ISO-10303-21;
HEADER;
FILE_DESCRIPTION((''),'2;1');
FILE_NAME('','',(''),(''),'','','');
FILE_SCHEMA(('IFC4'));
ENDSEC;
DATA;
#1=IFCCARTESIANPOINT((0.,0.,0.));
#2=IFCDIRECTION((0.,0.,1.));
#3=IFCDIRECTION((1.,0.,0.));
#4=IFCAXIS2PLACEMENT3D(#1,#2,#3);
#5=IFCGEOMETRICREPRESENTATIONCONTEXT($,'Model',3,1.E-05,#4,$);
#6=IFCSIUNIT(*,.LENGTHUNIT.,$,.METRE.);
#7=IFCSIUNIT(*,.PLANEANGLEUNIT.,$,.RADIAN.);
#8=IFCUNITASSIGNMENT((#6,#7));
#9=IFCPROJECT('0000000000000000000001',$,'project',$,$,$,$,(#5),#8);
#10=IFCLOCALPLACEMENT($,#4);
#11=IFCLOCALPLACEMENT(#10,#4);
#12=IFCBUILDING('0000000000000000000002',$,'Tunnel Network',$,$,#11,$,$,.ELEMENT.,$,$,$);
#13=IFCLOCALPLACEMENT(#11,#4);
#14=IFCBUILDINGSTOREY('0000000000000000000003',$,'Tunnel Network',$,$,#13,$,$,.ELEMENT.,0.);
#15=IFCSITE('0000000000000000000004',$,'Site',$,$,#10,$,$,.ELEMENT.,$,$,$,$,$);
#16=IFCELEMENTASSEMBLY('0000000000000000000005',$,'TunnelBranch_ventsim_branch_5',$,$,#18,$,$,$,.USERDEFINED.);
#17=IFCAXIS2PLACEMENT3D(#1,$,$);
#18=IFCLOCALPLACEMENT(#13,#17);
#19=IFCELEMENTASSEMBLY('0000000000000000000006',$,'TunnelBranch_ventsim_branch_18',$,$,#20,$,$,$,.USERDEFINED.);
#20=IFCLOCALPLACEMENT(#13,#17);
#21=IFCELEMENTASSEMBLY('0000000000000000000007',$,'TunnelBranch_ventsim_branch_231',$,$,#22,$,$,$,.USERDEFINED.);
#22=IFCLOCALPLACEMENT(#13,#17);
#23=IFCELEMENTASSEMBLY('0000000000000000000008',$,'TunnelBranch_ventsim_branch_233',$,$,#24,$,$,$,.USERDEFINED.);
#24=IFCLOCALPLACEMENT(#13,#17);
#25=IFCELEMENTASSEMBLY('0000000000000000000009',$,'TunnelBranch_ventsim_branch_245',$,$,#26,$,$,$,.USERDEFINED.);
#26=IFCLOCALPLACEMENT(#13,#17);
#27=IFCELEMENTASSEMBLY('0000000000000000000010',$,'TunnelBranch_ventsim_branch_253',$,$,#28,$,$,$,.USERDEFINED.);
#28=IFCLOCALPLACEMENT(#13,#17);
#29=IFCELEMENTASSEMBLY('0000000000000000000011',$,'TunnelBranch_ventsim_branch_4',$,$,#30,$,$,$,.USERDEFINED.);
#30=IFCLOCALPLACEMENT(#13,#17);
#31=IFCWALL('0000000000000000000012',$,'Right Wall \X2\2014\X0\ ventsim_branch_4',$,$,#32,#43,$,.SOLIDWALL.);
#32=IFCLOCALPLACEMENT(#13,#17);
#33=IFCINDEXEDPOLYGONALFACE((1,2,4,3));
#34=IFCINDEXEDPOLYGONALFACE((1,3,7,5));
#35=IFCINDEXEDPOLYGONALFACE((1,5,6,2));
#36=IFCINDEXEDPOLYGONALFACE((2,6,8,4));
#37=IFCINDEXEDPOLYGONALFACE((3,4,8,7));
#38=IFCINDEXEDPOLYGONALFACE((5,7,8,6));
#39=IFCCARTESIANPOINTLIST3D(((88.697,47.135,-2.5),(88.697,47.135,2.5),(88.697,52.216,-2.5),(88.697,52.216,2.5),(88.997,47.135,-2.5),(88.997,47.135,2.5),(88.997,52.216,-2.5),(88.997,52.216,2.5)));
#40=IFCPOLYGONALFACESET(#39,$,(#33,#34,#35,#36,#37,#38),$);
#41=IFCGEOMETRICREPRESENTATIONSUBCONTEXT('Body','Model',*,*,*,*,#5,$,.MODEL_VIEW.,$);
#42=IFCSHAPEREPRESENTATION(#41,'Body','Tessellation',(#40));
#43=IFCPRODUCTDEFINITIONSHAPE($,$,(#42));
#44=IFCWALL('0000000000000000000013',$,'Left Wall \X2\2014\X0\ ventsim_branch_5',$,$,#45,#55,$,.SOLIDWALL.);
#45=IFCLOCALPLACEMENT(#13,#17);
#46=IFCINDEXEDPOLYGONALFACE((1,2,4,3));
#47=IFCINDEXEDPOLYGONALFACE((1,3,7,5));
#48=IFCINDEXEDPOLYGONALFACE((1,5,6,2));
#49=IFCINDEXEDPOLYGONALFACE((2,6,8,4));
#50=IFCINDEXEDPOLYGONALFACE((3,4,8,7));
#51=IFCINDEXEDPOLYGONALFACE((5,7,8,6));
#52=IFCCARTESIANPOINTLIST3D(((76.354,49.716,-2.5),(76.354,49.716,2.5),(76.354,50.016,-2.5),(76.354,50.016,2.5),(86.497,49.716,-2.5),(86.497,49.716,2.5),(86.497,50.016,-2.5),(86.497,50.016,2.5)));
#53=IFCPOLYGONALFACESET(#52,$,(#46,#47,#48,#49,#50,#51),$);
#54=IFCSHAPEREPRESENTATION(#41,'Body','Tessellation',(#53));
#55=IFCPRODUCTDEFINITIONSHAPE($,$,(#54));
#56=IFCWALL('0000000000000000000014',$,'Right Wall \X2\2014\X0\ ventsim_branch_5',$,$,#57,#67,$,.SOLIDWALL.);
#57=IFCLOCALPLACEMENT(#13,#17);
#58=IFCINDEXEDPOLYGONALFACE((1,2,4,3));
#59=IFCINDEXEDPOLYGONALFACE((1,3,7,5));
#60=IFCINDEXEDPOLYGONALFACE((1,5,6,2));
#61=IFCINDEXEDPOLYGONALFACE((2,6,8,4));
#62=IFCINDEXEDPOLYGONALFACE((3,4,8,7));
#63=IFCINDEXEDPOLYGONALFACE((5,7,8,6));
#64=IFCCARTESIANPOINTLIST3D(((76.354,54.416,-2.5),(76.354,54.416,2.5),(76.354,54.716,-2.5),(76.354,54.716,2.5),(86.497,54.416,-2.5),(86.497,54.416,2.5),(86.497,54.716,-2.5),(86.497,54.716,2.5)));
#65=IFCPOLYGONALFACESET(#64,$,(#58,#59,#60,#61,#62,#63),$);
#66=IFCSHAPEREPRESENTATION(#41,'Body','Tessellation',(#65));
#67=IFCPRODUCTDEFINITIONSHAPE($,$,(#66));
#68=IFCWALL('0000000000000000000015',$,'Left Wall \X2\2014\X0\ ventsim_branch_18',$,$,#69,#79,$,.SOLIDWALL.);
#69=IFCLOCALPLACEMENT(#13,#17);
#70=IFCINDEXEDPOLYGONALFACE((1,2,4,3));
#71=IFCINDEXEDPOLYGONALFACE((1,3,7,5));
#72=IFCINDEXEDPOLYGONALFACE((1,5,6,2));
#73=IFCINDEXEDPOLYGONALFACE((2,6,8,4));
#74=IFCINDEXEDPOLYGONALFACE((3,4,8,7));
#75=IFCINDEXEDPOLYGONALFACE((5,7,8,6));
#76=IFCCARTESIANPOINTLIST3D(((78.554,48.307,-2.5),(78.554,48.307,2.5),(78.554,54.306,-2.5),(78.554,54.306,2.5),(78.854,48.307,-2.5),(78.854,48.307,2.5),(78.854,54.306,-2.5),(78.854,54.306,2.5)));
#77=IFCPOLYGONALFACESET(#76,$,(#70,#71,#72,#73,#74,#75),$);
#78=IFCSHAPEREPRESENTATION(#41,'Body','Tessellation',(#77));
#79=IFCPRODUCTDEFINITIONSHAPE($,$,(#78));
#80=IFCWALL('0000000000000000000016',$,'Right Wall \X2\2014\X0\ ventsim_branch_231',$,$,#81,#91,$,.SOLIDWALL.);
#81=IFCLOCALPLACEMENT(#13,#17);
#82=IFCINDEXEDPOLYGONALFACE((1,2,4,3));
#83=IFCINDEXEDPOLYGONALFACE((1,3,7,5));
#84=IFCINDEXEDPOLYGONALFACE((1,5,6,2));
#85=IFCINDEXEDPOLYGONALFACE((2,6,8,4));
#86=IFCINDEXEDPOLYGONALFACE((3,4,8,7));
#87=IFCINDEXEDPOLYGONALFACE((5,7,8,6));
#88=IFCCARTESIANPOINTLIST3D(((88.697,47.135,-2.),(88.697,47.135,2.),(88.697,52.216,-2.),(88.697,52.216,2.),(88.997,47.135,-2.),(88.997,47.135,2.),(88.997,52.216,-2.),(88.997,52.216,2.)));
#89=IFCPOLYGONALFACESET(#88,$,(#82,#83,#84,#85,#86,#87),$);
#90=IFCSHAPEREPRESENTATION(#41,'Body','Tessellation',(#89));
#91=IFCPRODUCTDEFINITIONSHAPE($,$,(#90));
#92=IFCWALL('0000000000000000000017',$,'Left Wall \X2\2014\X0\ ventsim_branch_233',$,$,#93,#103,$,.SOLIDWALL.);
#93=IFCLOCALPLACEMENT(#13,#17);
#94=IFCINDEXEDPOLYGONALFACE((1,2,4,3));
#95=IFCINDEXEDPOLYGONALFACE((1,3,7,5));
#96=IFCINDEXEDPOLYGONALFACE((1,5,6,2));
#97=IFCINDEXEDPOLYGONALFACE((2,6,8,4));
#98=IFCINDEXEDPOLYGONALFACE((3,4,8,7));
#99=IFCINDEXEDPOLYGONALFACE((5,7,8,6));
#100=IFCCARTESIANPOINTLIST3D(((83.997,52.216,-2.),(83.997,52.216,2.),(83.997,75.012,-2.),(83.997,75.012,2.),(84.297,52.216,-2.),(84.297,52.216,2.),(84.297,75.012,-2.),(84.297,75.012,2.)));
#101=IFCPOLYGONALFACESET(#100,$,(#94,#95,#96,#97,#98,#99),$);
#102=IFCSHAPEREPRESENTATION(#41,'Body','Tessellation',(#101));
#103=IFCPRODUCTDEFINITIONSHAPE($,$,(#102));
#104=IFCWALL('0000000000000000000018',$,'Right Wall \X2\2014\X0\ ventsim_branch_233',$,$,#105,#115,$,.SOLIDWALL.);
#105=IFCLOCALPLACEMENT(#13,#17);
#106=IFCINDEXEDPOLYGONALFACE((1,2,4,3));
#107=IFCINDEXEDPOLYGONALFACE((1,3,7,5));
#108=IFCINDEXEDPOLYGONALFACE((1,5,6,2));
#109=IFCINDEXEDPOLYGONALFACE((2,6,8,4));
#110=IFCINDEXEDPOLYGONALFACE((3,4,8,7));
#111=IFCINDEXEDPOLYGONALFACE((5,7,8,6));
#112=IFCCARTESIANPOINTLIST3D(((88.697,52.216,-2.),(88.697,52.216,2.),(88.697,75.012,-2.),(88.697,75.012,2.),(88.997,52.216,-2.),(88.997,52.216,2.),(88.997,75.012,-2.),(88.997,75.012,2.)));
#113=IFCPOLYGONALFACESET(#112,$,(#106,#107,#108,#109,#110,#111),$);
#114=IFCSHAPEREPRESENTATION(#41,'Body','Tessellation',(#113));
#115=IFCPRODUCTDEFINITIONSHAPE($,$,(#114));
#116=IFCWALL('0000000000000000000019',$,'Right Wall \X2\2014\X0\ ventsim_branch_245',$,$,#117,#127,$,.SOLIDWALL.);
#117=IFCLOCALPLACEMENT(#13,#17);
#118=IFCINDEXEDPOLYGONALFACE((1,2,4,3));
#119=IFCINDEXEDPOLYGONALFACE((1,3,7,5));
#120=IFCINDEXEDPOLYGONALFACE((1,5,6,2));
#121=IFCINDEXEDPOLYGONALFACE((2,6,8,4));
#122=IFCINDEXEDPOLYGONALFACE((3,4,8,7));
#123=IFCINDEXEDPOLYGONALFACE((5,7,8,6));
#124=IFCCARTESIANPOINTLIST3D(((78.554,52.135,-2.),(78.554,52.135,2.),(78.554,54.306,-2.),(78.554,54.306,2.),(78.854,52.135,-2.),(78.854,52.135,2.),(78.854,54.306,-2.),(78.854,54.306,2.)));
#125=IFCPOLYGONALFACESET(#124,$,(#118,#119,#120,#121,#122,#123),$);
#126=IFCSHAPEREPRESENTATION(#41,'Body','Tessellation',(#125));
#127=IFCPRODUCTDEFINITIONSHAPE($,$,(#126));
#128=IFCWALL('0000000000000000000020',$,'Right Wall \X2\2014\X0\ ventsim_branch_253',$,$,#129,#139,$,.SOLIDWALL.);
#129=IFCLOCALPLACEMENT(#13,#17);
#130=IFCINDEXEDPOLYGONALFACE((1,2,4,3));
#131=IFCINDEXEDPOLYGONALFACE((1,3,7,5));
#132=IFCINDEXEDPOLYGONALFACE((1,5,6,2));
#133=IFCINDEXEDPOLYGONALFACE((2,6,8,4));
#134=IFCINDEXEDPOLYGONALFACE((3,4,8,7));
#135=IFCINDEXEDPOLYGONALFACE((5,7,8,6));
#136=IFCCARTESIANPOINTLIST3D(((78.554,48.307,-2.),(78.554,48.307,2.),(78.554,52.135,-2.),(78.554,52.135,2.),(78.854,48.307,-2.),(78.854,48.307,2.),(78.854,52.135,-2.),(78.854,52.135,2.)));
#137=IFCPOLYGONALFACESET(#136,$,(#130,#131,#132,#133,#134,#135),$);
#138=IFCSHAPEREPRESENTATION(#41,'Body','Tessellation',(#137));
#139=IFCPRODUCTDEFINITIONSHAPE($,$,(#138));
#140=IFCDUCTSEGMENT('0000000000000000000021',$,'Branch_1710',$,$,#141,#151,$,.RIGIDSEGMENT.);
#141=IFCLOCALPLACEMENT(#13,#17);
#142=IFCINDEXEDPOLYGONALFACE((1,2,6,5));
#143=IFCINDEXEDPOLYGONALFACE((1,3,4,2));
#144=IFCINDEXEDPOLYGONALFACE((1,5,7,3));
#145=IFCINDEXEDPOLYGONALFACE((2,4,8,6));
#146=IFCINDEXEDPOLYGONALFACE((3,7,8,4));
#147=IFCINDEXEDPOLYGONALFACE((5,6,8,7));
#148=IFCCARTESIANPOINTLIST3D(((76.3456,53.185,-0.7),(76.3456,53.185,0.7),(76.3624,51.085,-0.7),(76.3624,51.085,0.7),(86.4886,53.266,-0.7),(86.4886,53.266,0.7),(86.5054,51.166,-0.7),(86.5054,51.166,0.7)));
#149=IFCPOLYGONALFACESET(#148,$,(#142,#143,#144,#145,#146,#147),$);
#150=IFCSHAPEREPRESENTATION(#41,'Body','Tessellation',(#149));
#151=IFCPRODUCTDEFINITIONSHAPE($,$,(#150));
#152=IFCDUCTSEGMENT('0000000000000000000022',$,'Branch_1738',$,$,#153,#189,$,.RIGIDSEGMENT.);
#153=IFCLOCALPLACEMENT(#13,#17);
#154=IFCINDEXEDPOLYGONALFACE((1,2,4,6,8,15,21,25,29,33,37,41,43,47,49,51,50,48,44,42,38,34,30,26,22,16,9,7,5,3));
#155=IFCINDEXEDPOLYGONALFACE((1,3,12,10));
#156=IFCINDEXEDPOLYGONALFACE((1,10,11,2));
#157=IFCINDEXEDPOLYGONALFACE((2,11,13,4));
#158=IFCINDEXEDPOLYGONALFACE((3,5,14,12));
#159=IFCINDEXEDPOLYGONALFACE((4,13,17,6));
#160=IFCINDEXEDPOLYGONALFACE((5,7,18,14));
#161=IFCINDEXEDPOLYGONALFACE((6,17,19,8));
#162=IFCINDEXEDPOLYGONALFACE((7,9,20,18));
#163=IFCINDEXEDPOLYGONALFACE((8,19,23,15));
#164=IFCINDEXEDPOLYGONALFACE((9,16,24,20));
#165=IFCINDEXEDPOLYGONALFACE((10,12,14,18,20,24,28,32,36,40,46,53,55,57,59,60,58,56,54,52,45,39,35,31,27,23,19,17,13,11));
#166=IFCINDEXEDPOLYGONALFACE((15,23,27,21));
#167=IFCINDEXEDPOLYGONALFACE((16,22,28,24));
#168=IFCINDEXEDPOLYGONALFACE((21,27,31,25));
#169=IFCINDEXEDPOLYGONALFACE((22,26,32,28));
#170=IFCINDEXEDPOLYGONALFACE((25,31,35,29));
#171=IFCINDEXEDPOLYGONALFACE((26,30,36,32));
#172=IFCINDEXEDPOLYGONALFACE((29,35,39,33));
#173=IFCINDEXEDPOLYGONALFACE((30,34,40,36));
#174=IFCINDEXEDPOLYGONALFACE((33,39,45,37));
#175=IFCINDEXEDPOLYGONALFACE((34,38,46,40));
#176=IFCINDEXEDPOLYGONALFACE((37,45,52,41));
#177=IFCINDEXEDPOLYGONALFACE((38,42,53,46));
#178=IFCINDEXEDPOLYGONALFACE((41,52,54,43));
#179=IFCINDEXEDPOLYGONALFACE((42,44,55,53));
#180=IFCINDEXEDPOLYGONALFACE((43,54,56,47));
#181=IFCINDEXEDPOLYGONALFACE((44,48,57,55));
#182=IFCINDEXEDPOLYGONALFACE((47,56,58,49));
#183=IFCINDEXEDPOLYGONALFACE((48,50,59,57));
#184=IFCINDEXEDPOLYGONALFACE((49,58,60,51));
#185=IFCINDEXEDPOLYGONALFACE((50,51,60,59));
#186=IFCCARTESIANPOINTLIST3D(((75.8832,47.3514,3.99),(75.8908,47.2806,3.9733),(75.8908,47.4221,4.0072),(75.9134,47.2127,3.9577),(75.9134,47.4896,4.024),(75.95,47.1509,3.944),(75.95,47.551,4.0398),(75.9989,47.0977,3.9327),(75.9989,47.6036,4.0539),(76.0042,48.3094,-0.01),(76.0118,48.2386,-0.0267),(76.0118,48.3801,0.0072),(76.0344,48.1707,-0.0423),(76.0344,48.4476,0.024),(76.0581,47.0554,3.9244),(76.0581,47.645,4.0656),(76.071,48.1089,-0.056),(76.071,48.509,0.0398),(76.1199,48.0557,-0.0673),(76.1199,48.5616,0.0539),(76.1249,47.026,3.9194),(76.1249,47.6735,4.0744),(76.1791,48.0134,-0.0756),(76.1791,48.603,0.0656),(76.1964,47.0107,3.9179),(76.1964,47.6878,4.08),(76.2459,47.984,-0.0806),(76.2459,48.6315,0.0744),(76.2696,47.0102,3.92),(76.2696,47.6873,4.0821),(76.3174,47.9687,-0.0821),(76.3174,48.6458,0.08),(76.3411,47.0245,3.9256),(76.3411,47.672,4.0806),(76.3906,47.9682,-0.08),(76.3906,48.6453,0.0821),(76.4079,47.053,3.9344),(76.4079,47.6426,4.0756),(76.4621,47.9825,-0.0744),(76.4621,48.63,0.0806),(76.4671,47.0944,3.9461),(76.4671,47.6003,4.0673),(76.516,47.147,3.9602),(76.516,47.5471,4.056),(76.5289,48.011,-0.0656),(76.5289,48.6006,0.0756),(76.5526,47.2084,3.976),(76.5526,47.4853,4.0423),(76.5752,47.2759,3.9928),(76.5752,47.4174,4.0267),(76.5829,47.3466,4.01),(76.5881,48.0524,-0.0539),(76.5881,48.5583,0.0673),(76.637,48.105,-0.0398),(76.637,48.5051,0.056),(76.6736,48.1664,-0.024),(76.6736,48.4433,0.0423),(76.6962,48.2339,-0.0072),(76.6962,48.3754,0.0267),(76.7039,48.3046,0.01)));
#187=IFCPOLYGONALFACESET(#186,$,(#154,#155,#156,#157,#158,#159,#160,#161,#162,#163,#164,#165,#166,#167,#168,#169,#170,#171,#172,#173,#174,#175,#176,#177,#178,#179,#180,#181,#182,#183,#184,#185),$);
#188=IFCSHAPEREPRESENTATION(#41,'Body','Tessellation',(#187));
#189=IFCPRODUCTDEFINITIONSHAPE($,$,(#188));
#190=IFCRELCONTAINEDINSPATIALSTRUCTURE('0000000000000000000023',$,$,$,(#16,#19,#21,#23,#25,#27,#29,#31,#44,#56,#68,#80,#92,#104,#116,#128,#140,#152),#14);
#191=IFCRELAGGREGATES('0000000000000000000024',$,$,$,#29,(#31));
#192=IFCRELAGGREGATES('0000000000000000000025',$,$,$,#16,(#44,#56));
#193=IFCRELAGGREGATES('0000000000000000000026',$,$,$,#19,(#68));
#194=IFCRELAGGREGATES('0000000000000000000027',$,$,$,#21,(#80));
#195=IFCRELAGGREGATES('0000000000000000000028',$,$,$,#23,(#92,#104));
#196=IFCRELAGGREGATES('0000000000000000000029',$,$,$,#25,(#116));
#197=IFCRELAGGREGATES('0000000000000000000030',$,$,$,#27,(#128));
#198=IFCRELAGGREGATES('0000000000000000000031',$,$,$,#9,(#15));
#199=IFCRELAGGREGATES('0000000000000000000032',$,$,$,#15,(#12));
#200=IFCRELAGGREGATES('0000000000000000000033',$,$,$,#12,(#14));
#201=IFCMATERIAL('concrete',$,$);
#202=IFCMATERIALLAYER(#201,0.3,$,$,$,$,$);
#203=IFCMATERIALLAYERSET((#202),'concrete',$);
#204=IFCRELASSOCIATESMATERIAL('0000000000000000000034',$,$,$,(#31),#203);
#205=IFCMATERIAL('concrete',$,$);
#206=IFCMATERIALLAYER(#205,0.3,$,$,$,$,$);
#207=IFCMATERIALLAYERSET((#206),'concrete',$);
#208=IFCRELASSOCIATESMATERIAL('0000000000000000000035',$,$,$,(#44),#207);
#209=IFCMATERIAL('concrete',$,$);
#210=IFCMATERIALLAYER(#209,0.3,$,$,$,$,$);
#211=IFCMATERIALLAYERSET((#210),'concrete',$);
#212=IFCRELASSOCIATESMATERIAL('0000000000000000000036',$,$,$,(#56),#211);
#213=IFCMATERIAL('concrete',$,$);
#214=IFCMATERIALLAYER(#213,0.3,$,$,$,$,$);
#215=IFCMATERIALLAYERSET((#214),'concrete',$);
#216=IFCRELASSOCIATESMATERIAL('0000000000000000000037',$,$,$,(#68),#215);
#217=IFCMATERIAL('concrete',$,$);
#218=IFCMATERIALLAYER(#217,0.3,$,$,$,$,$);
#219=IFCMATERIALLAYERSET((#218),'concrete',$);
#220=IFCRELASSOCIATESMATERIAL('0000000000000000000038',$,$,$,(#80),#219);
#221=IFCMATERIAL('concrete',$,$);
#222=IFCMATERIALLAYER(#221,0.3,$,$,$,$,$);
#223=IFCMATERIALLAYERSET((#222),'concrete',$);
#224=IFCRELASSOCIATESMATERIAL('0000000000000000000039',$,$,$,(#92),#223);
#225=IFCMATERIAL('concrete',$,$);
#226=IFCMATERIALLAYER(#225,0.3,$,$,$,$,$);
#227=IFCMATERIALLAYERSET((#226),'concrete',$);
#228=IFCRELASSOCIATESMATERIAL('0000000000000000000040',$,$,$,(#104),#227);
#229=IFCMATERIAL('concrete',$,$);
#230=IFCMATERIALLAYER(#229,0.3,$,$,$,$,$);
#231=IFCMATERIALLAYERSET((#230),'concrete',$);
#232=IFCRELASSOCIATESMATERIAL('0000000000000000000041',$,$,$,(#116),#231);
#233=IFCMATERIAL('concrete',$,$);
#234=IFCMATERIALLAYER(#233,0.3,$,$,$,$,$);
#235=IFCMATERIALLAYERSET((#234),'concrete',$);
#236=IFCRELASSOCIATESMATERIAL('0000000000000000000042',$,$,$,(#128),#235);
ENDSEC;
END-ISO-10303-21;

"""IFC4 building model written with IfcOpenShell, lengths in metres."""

from ifc_helpers import new_model, si_unit, frame, origin_with_axes, origin_2d_with_axis, place, context, subcontext, project, spatial, rectangle, circle, extrude, material, layer, layer_set, layer_usage, element, aggregate, save


model = new_model("IFC4")

# Units and contexts
model_context = context("Model", 3, precision=1e-05, world=origin_with_axes())
body_context = subcontext(model_context, "Body", "Model", "MODEL_VIEW")
ifc_project = project(units=[si_unit("LENGTHUNIT", "METRE"), si_unit("PLANEANGLEUNIT", "RADIAN")], contexts=[model_context])

# Site, building, storey
site_placement = place(None, origin_with_axes())
site = spatial("IfcSite", under=ifc_project, at=site_placement, Name="Site", CompositionType="ELEMENT")
building_placement = place(site_placement, origin_with_axes())
building = spatial("IfcBuilding", under=site, at=building_placement, Name="Tunnel Network", CompositionType="ELEMENT")
storey_placement = place(building_placement, origin_with_axes())
storey = spatial("IfcBuildingStorey", under=building, at=storey_placement, Name="Tunnel Network", CompositionType="ELEMENT", Elevation=0.0)

# Element assemblies
assembly_1_placement = place(storey_placement, frame((86.497, 49.866, 0.0), z_axis=(-1.0, 0.0, 0.0), x_axis=(0.0, 1.0, 0.0)))
assembly_1 = element("IfcElementAssembly", 1, at=assembly_1_placement, inside=storey, Name="TunnelBranch_ventsim_branch_5", PredefinedType="USERDEFINED")
assembly_2_placement = place(storey_placement, frame((78.704, 54.306, 0.0), z_axis=(0.0, -1.0, 0.0), x_axis=(-1.0, 0.0, 0.0)))
assembly_2 = element("IfcElementAssembly", 2, at=assembly_2_placement, inside=storey, Name="TunnelBranch_ventsim_branch_18", PredefinedType="USERDEFINED")
assembly_3_placement = place(storey_placement, frame((84.147, 47.135, 0.0), z_axis=(0.0, 1.0, 0.0), x_axis=(1.0, 0.0, 0.0)))
assembly_3 = element("IfcElementAssembly", 3, at=assembly_3_placement, inside=storey, Name="TunnelBranch_ventsim_branch_231", PredefinedType="USERDEFINED")
assembly_4_placement = place(storey_placement, frame((84.147, 52.216, 0.0), z_axis=(0.0, 1.0, 0.0), x_axis=(1.0, 0.0, 0.0)))
assembly_4 = element("IfcElementAssembly", 4, at=assembly_4_placement, inside=storey, Name="TunnelBranch_ventsim_branch_233", PredefinedType="USERDEFINED")
assembly_5_placement = place(storey_placement, frame((74.004, 52.135, 0.0), z_axis=(0.0, 1.0, 0.0), x_axis=(1.0, 0.0, 0.0)))
assembly_5 = element("IfcElementAssembly", 5, at=assembly_5_placement, inside=storey, Name="TunnelBranch_ventsim_branch_245", PredefinedType="USERDEFINED")
assembly_6_placement = place(storey_placement, frame((74.004, 48.307, 0.0), z_axis=(0.0, 1.0, 0.0), x_axis=(1.0, 0.0, 0.0)))
assembly_6 = element("IfcElementAssembly", 6, at=assembly_6_placement, inside=storey, Name="TunnelBranch_ventsim_branch_253", PredefinedType="USERDEFINED")

# Element assembly, wall
assembly_7_placement = place(storey_placement, frame((84.147, 47.135, 0.0), z_axis=(0.0, 1.0, 0.0), x_axis=(1.0, 0.0, 0.0)))
assembly_7 = element("IfcElementAssembly", 7, at=assembly_7_placement, inside=storey, Name="TunnelBranch_ventsim_branch_4", PredefinedType="USERDEFINED")
ifc_material_1 = material(Name="concrete")
ifc_layer_1 = layer(ifc_material_1, 0.3)
ifc_layer_set_1 = layer_set([ifc_layer_1], Name="concrete")
ifc_layer_usage_1 = layer_usage(ifc_layer_set_1, "AXIS2", "POSITIVE", 0.0)
wall_1_placement = place(storey_placement, frame((88.847, 47.135, 0.0), z_axis=(0.0, 1.0, 0.0), x_axis=(1.0, 0.0, 0.0)))
wall_1 = element("IfcWall", 8, at=wall_1_placement, inside=storey, material=ifc_layer_usage_1, Name="Right Wall — ventsim_branch_4", PredefinedType="SOLIDWALL", context=body_context, shape_type="SweptSolid", body=[
    extrude(rectangle(XDim=0.3, YDim=5.0, at=origin_2d_with_axis()), origin_with_axes(), (0.0, 0.0, 1.0), 5.081),
])
aggregate(assembly_7, [wall_1])

# Walls
ifc_material_2 = material(Name="concrete")
ifc_layer_2 = layer(ifc_material_2, 0.3)
ifc_layer_set_2 = layer_set([ifc_layer_2], Name="concrete")
ifc_layer_usage_2 = layer_usage(ifc_layer_set_2, "AXIS2", "POSITIVE", 0.0)
wall_2_placement = place(storey_placement, frame((86.497, 49.866, 0.0), z_axis=(-1.0, 0.0, 0.0), x_axis=(0.0, 1.0, 0.0)))
wall_2 = element("IfcWall", 9, at=wall_2_placement, inside=storey, material=ifc_layer_usage_2, Name="Left Wall — ventsim_branch_5", PredefinedType="SOLIDWALL", context=body_context, shape_type="SweptSolid", body=[
    extrude(rectangle(XDim=0.3, YDim=5.0, at=origin_2d_with_axis()), origin_with_axes(), (0.0, 0.0, 1.0), 10.143),
])
ifc_material_3 = material(Name="concrete")
ifc_layer_3 = layer(ifc_material_3, 0.3)
ifc_layer_set_3 = layer_set([ifc_layer_3], Name="concrete")
ifc_layer_usage_3 = layer_usage(ifc_layer_set_3, "AXIS2", "POSITIVE", 0.0)
wall_3_placement = place(storey_placement, frame((86.497, 54.566, 0.0), z_axis=(-1.0, 0.0, 0.0), x_axis=(0.0, 1.0, 0.0)))
wall_3 = element("IfcWall", 10, at=wall_3_placement, inside=storey, material=ifc_layer_usage_3, Name="Right Wall — ventsim_branch_5", PredefinedType="SOLIDWALL", context=body_context, shape_type="SweptSolid", body=[
    extrude(rectangle(XDim=0.3, YDim=5.0, at=origin_2d_with_axis()), origin_with_axes(), (0.0, 0.0, 1.0), 10.143),
])
aggregate(assembly_1, [wall_2, wall_3])
ifc_material_4 = material(Name="concrete")
ifc_layer_4 = layer(ifc_material_4, 0.3)
ifc_layer_set_4 = layer_set([ifc_layer_4], Name="concrete")
ifc_layer_usage_4 = layer_usage(ifc_layer_set_4, "AXIS2", "POSITIVE", 0.0)
wall_4_placement = place(storey_placement, frame((78.704, 54.306, 0.0), z_axis=(0.0, -1.0, 0.0), x_axis=(-1.0, 0.0, 0.0)))
wall_4 = element("IfcWall", 11, at=wall_4_placement, inside=storey, material=ifc_layer_usage_4, Name="Left Wall — ventsim_branch_18", PredefinedType="SOLIDWALL", context=body_context, shape_type="SweptSolid", body=[
    extrude(rectangle(XDim=0.3, YDim=5.0, at=origin_2d_with_axis()), origin_with_axes(), (0.0, 0.0, 1.0), 5.999),
])
aggregate(assembly_2, [wall_4])
ifc_material_5 = material(Name="concrete")
ifc_layer_5 = layer(ifc_material_5, 0.3)
ifc_layer_set_5 = layer_set([ifc_layer_5], Name="concrete")
ifc_layer_usage_5 = layer_usage(ifc_layer_set_5, "AXIS2", "POSITIVE", 0.0)
wall_5_placement = place(storey_placement, frame((88.847, 47.135, 0.0), z_axis=(0.0, 1.0, 0.0), x_axis=(1.0, 0.0, 0.0)))
wall_5 = element("IfcWall", 12, at=wall_5_placement, inside=storey, material=ifc_layer_usage_5, Name="Right Wall — ventsim_branch_231", PredefinedType="SOLIDWALL", context=body_context, shape_type="SweptSolid", body=[
    extrude(rectangle(XDim=0.3, YDim=4.0, at=origin_2d_with_axis()), origin_with_axes(), (0.0, 0.0, 1.0), 5.081),
])
aggregate(assembly_3, [wall_5])
ifc_material_6 = material(Name="concrete")
ifc_layer_6 = layer(ifc_material_6, 0.3)
ifc_layer_set_6 = layer_set([ifc_layer_6], Name="concrete")
ifc_layer_usage_6 = layer_usage(ifc_layer_set_6, "AXIS2", "POSITIVE", 0.0)
wall_6_placement = place(storey_placement, frame((84.147, 52.216, 0.0), z_axis=(0.0, 1.0, 0.0), x_axis=(1.0, 0.0, 0.0)))
wall_6 = element("IfcWall", 13, at=wall_6_placement, inside=storey, material=ifc_layer_usage_6, Name="Left Wall — ventsim_branch_233", PredefinedType="SOLIDWALL", context=body_context, shape_type="SweptSolid", body=[
    extrude(rectangle(XDim=0.3, YDim=4.0, at=origin_2d_with_axis()), origin_with_axes(), (0.0, 0.0, 1.0), 22.796),
])
ifc_material_7 = material(Name="concrete")
ifc_layer_7 = layer(ifc_material_7, 0.3)
ifc_layer_set_7 = layer_set([ifc_layer_7], Name="concrete")
ifc_layer_usage_7 = layer_usage(ifc_layer_set_7, "AXIS2", "POSITIVE", 0.0)
wall_7_placement = place(storey_placement, frame((88.847, 52.216, 0.0), z_axis=(0.0, 1.0, 0.0), x_axis=(1.0, 0.0, 0.0)))
wall_7 = element("IfcWall", 14, at=wall_7_placement, inside=storey, material=ifc_layer_usage_7, Name="Right Wall — ventsim_branch_233", PredefinedType="SOLIDWALL", context=body_context, shape_type="SweptSolid", body=[
    extrude(rectangle(XDim=0.3, YDim=4.0, at=origin_2d_with_axis()), origin_with_axes(), (0.0, 0.0, 1.0), 22.796),
])
aggregate(assembly_4, [wall_6, wall_7])
ifc_material_8 = material(Name="concrete")
ifc_layer_8 = layer(ifc_material_8, 0.3)
ifc_layer_set_8 = layer_set([ifc_layer_8], Name="concrete")
ifc_layer_usage_8 = layer_usage(ifc_layer_set_8, "AXIS2", "POSITIVE", 0.0)
wall_8_placement = place(storey_placement, frame((78.704, 52.135, 0.0), z_axis=(0.0, 1.0, 0.0), x_axis=(1.0, 0.0, 0.0)))
wall_8 = element("IfcWall", 15, at=wall_8_placement, inside=storey, material=ifc_layer_usage_8, Name="Right Wall — ventsim_branch_245", PredefinedType="SOLIDWALL", context=body_context, shape_type="SweptSolid", body=[
    extrude(rectangle(XDim=0.3, YDim=4.0, at=origin_2d_with_axis()), origin_with_axes(), (0.0, 0.0, 1.0), 2.171),
])
aggregate(assembly_5, [wall_8])
ifc_material_9 = material(Name="concrete")
ifc_layer_9 = layer(ifc_material_9, 0.3)
ifc_layer_set_9 = layer_set([ifc_layer_9], Name="concrete")
ifc_layer_usage_9 = layer_usage(ifc_layer_set_9, "AXIS2", "POSITIVE", 0.0)
wall_9_placement = place(storey_placement, frame((78.704, 48.307, 0.0), z_axis=(0.0, 1.0, 0.0), x_axis=(1.0, 0.0, 0.0)))
wall_9 = element("IfcWall", 16, at=wall_9_placement, inside=storey, material=ifc_layer_usage_9, Name="Right Wall — ventsim_branch_253", PredefinedType="SOLIDWALL", context=body_context, shape_type="SweptSolid", body=[
    extrude(rectangle(XDim=0.3, YDim=4.0, at=origin_2d_with_axis()), origin_with_axes(), (0.0, 0.0, 1.0), 3.828),
])
aggregate(assembly_6, [wall_9])

# Duct segments
duct_segment_1_placement = place(storey_placement, frame((76.354, 52.135, 0.0), z_axis=(0.999968, 0.007986, 0.0), x_axis=(0.0, 0.0, 1.0)))
element("IfcDuctSegment", 17, at=duct_segment_1_placement, inside=storey, Name="Branch_1710", PredefinedType="RIGIDSEGMENT", context=body_context, shape_type="SweptSolid", body=[
    extrude(rectangle(XDim=1.4, YDim=2.1, at=origin_2d_with_axis()), origin_with_axes(), (0.0, 0.0, 1.0), 10.1433),
])
duct_segment_2_placement = place(storey_placement, frame((76.233, 47.349, 4.0), z_axis=(0.029405, 0.232812, -0.972077), x_axis=(0.999568, -0.006849, 0.028597)))
element("IfcDuctSegment", 18, at=duct_segment_2_placement, inside=storey, Name="Branch_1738", PredefinedType="RIGIDSEGMENT", context=body_context, shape_type="SweptSolid", body=[
    extrude(circle(Radius=0.35, at=origin_2d_with_axis()), origin_with_axes(), (0.0, 0.0, 1.0), 4.1149),
])

save(model, "model.ifc")
